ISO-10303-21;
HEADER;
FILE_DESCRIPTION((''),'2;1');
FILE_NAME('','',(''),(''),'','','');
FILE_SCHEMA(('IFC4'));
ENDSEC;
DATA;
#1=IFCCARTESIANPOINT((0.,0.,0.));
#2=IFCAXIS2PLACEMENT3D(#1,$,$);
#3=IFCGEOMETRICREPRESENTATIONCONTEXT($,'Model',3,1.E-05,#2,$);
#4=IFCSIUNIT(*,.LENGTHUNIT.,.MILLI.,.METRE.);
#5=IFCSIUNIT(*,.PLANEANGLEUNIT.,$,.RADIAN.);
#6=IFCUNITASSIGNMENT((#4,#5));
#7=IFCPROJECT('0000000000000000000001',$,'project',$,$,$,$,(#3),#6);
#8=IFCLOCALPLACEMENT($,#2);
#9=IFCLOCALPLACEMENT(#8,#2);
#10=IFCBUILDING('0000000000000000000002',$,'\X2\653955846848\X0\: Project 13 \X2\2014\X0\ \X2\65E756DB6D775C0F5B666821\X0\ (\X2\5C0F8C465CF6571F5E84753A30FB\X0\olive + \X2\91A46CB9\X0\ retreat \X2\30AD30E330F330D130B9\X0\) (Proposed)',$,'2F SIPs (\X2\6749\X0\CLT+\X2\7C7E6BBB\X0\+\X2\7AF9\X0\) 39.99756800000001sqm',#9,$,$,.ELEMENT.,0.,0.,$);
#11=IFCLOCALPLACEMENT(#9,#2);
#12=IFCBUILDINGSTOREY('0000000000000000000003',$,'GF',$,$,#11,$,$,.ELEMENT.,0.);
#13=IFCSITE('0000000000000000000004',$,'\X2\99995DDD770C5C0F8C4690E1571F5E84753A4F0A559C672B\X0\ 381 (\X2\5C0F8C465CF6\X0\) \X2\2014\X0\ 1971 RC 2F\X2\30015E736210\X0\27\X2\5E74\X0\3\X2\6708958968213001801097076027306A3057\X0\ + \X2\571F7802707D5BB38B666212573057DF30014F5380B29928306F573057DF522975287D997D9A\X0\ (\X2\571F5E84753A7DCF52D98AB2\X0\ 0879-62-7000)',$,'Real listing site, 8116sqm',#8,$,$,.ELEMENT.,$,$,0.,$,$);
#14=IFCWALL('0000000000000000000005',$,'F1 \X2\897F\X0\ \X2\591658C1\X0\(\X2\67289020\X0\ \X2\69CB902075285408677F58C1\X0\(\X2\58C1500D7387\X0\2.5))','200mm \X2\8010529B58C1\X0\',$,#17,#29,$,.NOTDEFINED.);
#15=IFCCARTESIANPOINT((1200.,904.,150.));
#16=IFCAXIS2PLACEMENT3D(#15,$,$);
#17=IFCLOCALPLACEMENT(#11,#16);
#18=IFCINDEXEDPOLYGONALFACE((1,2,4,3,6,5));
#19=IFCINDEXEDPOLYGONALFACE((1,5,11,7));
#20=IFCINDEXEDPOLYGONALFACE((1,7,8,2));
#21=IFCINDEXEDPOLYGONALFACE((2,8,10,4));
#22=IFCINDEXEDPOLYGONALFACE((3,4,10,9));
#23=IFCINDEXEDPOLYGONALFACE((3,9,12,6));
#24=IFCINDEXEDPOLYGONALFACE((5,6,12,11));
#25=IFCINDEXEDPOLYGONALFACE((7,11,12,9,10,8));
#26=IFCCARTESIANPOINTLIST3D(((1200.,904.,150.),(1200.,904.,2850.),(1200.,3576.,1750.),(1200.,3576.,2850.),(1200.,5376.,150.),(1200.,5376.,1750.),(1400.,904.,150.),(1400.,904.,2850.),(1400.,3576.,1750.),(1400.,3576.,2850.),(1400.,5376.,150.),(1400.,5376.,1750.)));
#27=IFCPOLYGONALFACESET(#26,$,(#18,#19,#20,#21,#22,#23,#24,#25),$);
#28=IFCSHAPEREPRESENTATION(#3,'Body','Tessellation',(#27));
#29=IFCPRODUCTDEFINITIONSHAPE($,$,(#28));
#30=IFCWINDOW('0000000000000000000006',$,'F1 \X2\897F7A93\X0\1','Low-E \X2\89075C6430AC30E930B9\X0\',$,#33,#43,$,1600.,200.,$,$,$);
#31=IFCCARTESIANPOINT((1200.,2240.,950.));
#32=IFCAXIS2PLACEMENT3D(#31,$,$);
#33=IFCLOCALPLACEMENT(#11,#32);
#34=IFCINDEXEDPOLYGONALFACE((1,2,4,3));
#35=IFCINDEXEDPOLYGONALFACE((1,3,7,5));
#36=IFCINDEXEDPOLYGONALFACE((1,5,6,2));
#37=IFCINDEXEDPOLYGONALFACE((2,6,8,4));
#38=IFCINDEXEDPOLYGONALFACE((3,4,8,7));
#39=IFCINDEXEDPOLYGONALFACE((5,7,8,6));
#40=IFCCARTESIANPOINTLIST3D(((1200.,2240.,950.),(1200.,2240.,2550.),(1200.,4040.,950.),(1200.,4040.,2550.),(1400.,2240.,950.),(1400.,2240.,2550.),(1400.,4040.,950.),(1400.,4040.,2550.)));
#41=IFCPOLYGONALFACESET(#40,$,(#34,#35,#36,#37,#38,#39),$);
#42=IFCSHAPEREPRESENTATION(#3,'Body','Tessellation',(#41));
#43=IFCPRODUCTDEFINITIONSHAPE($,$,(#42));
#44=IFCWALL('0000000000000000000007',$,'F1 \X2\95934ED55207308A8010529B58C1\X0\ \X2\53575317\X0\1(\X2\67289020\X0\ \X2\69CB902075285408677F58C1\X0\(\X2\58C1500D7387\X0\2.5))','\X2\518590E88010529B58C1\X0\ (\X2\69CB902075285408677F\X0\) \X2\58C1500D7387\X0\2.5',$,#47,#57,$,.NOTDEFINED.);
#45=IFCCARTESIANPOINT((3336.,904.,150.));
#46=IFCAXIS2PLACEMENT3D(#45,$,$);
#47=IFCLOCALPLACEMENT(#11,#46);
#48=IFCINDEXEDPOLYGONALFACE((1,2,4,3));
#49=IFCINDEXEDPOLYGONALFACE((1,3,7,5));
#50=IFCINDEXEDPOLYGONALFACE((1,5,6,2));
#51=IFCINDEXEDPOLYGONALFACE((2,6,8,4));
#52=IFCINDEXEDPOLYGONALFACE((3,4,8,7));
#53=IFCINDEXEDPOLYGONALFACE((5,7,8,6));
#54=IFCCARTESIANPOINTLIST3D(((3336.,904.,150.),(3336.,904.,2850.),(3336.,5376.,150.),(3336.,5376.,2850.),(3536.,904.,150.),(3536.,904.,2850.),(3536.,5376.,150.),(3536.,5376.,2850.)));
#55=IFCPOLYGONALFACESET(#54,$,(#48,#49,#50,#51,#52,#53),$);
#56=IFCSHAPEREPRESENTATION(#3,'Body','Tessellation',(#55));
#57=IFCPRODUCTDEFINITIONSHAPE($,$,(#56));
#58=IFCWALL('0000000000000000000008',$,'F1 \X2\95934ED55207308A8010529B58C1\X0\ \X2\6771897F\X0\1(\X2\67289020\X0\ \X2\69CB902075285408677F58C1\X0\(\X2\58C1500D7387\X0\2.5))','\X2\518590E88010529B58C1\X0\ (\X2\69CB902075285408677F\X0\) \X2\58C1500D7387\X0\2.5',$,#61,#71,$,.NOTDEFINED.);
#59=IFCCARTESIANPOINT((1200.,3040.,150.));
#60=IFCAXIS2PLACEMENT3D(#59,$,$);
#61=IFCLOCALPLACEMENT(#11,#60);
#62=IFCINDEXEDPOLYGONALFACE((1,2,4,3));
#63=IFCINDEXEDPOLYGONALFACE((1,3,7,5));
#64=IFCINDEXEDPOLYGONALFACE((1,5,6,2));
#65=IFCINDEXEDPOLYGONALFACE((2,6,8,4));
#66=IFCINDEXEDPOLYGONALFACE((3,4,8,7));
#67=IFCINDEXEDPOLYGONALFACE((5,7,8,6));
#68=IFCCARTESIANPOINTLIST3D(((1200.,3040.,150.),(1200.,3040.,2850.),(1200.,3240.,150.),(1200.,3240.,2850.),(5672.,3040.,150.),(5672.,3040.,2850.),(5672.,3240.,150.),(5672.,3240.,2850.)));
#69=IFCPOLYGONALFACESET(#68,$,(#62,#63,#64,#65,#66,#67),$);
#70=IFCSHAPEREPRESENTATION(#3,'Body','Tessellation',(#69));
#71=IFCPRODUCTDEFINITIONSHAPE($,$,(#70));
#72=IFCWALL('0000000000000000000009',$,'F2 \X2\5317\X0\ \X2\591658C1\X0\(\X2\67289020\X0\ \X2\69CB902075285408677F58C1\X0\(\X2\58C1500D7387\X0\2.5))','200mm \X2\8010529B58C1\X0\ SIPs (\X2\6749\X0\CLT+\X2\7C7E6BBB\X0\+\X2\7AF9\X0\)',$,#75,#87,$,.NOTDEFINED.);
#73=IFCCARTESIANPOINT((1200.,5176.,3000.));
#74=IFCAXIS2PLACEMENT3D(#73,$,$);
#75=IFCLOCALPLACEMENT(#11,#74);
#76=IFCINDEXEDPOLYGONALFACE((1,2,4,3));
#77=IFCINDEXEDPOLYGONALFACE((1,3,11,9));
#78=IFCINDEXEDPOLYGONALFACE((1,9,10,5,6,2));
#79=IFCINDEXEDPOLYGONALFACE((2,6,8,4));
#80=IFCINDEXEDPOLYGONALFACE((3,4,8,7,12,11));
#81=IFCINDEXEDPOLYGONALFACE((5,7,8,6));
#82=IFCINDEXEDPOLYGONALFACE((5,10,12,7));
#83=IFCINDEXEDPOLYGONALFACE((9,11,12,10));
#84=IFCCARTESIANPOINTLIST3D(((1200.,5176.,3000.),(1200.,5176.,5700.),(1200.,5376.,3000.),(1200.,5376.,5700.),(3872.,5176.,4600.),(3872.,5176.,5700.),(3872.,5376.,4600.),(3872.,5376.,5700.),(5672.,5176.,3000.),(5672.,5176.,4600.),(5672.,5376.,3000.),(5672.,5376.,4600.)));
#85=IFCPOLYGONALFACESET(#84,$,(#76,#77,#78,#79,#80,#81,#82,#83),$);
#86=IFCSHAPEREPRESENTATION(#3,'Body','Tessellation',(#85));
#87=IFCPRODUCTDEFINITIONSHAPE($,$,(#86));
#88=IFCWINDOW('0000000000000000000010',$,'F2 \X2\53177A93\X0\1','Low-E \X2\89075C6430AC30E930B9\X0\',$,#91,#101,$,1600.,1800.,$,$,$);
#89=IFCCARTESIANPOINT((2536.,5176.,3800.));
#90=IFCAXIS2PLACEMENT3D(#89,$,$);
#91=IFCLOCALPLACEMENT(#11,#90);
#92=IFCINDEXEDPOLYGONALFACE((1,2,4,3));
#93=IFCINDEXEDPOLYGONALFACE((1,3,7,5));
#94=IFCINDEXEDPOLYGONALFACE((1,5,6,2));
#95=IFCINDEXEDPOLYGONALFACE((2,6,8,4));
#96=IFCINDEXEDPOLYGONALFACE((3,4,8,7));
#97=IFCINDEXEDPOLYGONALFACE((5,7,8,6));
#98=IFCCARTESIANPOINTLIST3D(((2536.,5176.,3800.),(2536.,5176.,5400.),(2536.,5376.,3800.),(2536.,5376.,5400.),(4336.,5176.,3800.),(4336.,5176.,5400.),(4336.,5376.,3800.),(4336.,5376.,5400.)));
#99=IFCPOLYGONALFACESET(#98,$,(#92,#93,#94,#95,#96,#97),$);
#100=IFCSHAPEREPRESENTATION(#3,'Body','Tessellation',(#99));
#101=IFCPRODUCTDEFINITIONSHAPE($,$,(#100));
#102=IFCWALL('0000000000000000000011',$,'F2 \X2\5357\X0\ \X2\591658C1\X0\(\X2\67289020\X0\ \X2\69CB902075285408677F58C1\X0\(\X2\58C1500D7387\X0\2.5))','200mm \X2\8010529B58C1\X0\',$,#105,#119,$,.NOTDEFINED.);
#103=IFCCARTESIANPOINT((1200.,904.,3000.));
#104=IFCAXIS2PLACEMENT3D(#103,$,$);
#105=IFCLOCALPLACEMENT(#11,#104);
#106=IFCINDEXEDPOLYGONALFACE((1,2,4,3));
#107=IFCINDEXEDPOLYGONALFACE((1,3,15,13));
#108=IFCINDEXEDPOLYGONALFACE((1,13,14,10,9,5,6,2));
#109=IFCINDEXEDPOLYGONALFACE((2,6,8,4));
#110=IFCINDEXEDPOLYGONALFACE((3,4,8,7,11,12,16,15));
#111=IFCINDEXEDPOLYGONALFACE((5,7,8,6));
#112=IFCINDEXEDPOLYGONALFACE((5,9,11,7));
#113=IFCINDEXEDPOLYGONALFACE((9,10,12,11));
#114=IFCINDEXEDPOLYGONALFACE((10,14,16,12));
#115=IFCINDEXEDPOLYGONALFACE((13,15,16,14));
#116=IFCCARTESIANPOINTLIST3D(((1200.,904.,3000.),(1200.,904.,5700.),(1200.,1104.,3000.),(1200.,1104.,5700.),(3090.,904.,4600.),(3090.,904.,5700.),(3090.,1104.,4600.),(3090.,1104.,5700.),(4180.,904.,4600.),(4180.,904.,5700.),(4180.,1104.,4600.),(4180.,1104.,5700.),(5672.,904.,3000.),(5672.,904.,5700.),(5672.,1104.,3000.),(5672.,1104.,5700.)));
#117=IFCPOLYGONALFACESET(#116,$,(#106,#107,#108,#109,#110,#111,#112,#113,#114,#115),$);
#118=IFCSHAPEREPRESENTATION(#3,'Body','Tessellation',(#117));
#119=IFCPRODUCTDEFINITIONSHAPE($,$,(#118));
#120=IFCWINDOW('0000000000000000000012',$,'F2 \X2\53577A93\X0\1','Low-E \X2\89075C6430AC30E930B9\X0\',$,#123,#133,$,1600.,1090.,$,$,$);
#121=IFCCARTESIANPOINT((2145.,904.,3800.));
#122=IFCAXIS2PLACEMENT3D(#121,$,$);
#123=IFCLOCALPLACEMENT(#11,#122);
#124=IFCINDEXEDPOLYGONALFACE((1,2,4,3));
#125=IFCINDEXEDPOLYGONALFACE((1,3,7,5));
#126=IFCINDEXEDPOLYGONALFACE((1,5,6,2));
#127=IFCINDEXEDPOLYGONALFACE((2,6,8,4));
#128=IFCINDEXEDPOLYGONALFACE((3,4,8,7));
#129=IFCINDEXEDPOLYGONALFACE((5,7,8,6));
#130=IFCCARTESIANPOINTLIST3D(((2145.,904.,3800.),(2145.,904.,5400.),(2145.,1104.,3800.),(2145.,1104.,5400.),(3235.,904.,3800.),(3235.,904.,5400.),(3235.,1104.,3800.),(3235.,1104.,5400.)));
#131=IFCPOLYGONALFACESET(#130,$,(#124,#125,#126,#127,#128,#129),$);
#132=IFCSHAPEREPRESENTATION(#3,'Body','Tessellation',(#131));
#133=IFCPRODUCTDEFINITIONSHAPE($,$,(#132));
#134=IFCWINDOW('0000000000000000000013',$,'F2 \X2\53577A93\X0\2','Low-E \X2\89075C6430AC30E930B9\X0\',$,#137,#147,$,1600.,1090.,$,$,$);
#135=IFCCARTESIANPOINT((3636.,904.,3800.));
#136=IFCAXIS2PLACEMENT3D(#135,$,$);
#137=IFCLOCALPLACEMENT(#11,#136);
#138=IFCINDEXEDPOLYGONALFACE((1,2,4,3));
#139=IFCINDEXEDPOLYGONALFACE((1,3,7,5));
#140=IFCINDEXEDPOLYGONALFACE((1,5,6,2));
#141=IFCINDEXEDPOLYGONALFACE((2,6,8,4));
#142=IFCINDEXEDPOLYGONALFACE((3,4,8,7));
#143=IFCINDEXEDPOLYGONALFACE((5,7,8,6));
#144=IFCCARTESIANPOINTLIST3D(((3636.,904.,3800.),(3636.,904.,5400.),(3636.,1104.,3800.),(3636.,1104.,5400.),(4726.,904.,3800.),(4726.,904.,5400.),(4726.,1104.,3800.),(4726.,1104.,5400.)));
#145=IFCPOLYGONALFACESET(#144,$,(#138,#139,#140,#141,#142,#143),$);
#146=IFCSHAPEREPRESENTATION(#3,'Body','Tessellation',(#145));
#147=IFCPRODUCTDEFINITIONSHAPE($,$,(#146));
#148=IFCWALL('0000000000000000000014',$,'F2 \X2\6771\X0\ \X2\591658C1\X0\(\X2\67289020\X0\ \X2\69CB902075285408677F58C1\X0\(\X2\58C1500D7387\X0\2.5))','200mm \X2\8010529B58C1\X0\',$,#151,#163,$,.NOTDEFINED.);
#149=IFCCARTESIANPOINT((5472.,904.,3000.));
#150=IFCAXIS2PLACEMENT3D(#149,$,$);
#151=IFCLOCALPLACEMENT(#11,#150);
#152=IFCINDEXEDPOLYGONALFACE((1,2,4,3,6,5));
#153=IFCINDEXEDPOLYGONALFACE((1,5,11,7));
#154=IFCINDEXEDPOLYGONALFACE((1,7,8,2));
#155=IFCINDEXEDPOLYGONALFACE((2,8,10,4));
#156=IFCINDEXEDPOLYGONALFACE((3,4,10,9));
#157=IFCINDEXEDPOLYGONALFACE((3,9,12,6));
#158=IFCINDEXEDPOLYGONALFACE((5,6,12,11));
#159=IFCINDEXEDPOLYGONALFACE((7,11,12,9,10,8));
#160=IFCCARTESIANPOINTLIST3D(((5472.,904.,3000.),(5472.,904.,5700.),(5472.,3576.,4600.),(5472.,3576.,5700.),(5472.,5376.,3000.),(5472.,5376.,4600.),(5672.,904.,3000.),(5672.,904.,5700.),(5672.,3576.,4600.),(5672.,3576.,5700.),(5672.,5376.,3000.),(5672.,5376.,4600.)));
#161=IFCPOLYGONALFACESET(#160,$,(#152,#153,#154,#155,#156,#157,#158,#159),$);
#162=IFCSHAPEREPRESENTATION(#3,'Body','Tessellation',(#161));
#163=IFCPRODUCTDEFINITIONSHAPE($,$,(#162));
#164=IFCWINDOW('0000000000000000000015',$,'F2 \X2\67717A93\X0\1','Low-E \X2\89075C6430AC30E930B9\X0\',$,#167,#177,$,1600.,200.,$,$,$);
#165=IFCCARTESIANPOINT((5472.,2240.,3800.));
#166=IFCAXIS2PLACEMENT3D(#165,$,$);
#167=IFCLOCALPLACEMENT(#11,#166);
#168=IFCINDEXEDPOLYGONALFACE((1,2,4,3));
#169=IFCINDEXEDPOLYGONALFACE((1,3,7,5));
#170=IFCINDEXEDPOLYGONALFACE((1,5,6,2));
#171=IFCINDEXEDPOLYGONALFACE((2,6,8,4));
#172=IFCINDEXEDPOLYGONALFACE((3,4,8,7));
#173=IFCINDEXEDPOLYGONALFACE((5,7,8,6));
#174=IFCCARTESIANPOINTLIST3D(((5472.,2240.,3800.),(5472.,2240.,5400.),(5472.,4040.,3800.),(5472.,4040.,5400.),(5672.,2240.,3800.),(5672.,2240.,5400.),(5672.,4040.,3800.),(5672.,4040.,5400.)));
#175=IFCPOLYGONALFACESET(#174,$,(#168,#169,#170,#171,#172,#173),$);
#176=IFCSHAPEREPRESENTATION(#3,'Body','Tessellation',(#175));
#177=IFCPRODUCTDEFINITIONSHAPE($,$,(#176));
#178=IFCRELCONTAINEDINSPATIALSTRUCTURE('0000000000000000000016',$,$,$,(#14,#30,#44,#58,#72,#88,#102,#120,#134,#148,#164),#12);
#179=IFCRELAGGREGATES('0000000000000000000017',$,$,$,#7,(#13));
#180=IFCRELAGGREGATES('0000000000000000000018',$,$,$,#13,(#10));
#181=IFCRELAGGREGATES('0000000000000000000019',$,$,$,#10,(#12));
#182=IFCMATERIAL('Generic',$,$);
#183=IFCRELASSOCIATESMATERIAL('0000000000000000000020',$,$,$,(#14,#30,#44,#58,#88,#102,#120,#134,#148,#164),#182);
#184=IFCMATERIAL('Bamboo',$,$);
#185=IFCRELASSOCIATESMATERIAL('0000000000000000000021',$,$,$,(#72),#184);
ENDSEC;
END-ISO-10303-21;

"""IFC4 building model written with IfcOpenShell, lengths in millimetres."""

from ifc_helpers import new_model, si_unit, frame, frame_2d, origin, place, context, project, spatial, rectangle, extrude, material, element, fill, save


model = new_model("IFC4")

# Units and contexts
model_context = context("Model", 3, precision=1e-05, world=origin())
ifc_project = project(units=[si_unit("LENGTHUNIT", "METRE", prefix="MILLI"), si_unit("PLANEANGLEUNIT", "RADIAN")], contexts=[model_context])

# Site, building, storey
site_placement = place(None, origin())
site = spatial("IfcSite", under=ifc_project, at=site_placement, Name="香川県小豆郡土庄町伊喜末 381 (小豆島) — 1971 RC 2F、平成27年3月閉校、耐震性なし + 土砂災害警戒地域、体育館は地域利用継続 (土庄町総務課 0879-62-7000)", ObjectType="Real listing site, 8116sqm", CompositionType="ELEMENT", RefElevation=0.0)
building_placement = place(site_placement, origin())
building = spatial("IfcBuilding", under=site, at=building_placement, Name="改善案: Project 13 — 旧四海小学校 (小豆島土庄町・olive + 醤油 retreat キャンパス) (Proposed)", ObjectType="2F SIPs (杉CLT+籾殻+竹) 39.99756800000001sqm", CompositionType="ELEMENT", ElevationOfRefHeight=0.0, ElevationOfTerrain=0.0)
storey_placement = place(building_placement, origin())
storey = spatial("IfcBuildingStorey", under=building, at=storey_placement, Name="GF", CompositionType="ELEMENT", Elevation=0.0)

# Shared definitions
ifc_material_1 = material(Name="Generic")

# Shared definitions
ifc_material_2 = material(Name="Bamboo")

# Wall, opening, window
wall_1_placement = place(storey_placement, frame((1200.0, 904.0, 150.0)))
wall_1 = element("IfcWall", 1, at=wall_1_placement, inside=storey, material=ifc_material_1, Name="F1 西 外壁(木造 構造用合板壁(壁倍率2.5))", Description="200mm 耐力壁", PredefinedType="NOTDEFINED", context=model_context, shape_type="SweptSolid", body=[
    extrude(rectangle(XDim=200.0, YDim=4472.0, at=frame_2d((100.0, 2236.0))), frame((1200.0, 904.0, 150.0)), (0.0, 0.0, 1.0), 2700.0),
])
opening_1_placement = place(storey_placement, frame((1200.0, 2240.0, 950.0)))
opening_1 = element("IfcOpeningElement", 2, at=opening_1_placement, cuts=wall_1, PredefinedType="NOTDEFINED", context=model_context, shape_type="SweptSolid", body=[
    extrude(rectangle(XDim=200.0, YDim=1800.0, at=frame_2d((100.0, 900.0))), frame((1200.0, 2240.0, 950.0)), (0.0, 0.0, 1.0), 1600.0),
])
window_1_placement = place(storey_placement, frame((1200.0, 2240.0, 950.0)))
window_1 = element("IfcWindow", 3, at=window_1_placement, inside=storey, material=ifc_material_1, Name="F1 西窓1", Description="Low-E 複層ガラス", OverallHeight=1600.0, OverallWidth=200.0, context=model_context, shape_type="SweptSolid", body=[
    extrude(rectangle(XDim=200.0, YDim=1800.0, at=frame_2d((100.0, 900.0))), frame((1200.0, 2240.0, 950.0)), (0.0, 0.0, 1.0), 1600.0),
])
fill(opening_1, window_1)

# Walls
wall_2_placement = place(storey_placement, frame((3336.0, 904.0, 150.0)))
element("IfcWall", 4, at=wall_2_placement, inside=storey, material=ifc_material_1, Name="F1 間仕切り耐力壁 南北1(木造 構造用合板壁(壁倍率2.5))", Description="内部耐力壁 (構造用合板) 壁倍率2.5", PredefinedType="NOTDEFINED", context=model_context, shape_type="SweptSolid", body=[
    extrude(rectangle(XDim=200.0, YDim=4472.0, at=frame_2d((100.0, 2236.0))), frame((3336.0, 904.0, 150.0)), (0.0, 0.0, 1.0), 2700.0),
])
wall_3_placement = place(storey_placement, frame((1200.0, 3040.0, 150.0)))
element("IfcWall", 5, at=wall_3_placement, inside=storey, material=ifc_material_1, Name="F1 間仕切り耐力壁 東西1(木造 構造用合板壁(壁倍率2.5))", Description="内部耐力壁 (構造用合板) 壁倍率2.5", PredefinedType="NOTDEFINED", context=model_context, shape_type="SweptSolid", body=[
    extrude(rectangle(XDim=4472.0, YDim=200.0, at=frame_2d((2236.0, 100.0))), frame((1200.0, 3040.0, 150.0)), (0.0, 0.0, 1.0), 2700.0),
])

# Wall, opening, window
wall_4_placement = place(storey_placement, frame((1200.0, 5176.0, 3000.0)))
wall_4 = element("IfcWall", 6, at=wall_4_placement, inside=storey, material=ifc_material_2, Name="F2 北 外壁(木造 構造用合板壁(壁倍率2.5))", Description="200mm 耐力壁 SIPs (杉CLT+籾殻+竹)", PredefinedType="NOTDEFINED", context=model_context, shape_type="SweptSolid", body=[
    extrude(rectangle(XDim=4472.0, YDim=200.0, at=frame_2d((2236.0, 100.0))), frame((1200.0, 5176.0, 3000.0)), (0.0, 0.0, 1.0), 2700.0),
])
opening_2_placement = place(storey_placement, frame((2536.0, 5176.0, 3800.0)))
opening_2 = element("IfcOpeningElement", 7, at=opening_2_placement, cuts=wall_4, PredefinedType="NOTDEFINED", context=model_context, shape_type="SweptSolid", body=[
    extrude(rectangle(XDim=1800.0, YDim=200.0, at=frame_2d((900.0, 100.0))), frame((2536.0, 5176.0, 3800.0)), (0.0, 0.0, 1.0), 1600.0),
])
window_2_placement = place(storey_placement, frame((2536.0, 5176.0, 3800.0)))
window_2 = element("IfcWindow", 8, at=window_2_placement, inside=storey, material=ifc_material_1, Name="F2 北窓1", Description="Low-E 複層ガラス", OverallHeight=1600.0, OverallWidth=1800.0, context=model_context, shape_type="SweptSolid", body=[
    extrude(rectangle(XDim=1800.0, YDim=200.0, at=frame_2d((900.0, 100.0))), frame((2536.0, 5176.0, 3800.0)), (0.0, 0.0, 1.0), 1600.0),
])
fill(opening_2, window_2)

# Wall, openings, windows
wall_5_placement = place(storey_placement, frame((1200.0, 904.0, 3000.0)))
wall_5 = element("IfcWall", 9, at=wall_5_placement, inside=storey, material=ifc_material_1, Name="F2 南 外壁(木造 構造用合板壁(壁倍率2.5))", Description="200mm 耐力壁", PredefinedType="NOTDEFINED", context=model_context, shape_type="SweptSolid", body=[
    extrude(rectangle(XDim=4472.0, YDim=200.0, at=frame_2d((2236.0, 100.0))), frame((1200.0, 904.0, 3000.0)), (0.0, 0.0, 1.0), 2700.0),
])
opening_3_placement = place(storey_placement, frame((2145.0, 904.0, 3800.0)))
opening_3 = element("IfcOpeningElement", 10, at=opening_3_placement, cuts=wall_5, PredefinedType="NOTDEFINED", context=model_context, shape_type="SweptSolid", body=[
    extrude(rectangle(XDim=1090.0, YDim=200.0, at=frame_2d((545.0, 100.0))), frame((2145.0, 904.0, 3800.0)), (0.0, 0.0, 1.0), 1600.0),
])
opening_4_placement = place(storey_placement, frame((3636.0, 904.0, 3800.0)))
opening_4 = element("IfcOpeningElement", 11, at=opening_4_placement, cuts=wall_5, PredefinedType="NOTDEFINED", context=model_context, shape_type="SweptSolid", body=[
    extrude(rectangle(XDim=1090.0, YDim=200.0, at=frame_2d((545.0, 100.0))), frame((3636.0, 904.0, 3800.0)), (0.0, 0.0, 1.0), 1600.0),
])
window_3_placement = place(storey_placement, frame((2145.0, 904.0, 3800.0)))
window_3 = element("IfcWindow", 12, at=window_3_placement, inside=storey, material=ifc_material_1, Name="F2 南窓1", Description="Low-E 複層ガラス", OverallHeight=1600.0, OverallWidth=1090.0, context=model_context, shape_type="SweptSolid", body=[
    extrude(rectangle(XDim=1090.0, YDim=200.0, at=frame_2d((545.0, 100.0))), frame((2145.0, 904.0, 3800.0)), (0.0, 0.0, 1.0), 1600.0),
])
fill(opening_3, window_3)
window_4_placement = place(storey_placement, frame((3636.0, 904.0, 3800.0)))
window_4 = element("IfcWindow", 13, at=window_4_placement, inside=storey, material=ifc_material_1, Name="F2 南窓2", Description="Low-E 複層ガラス", OverallHeight=1600.0, OverallWidth=1090.0, context=model_context, shape_type="SweptSolid", body=[
    extrude(rectangle(XDim=1090.0, YDim=200.0, at=frame_2d((545.0, 100.0))), frame((3636.0, 904.0, 3800.0)), (0.0, 0.0, 1.0), 1600.0),
])
fill(opening_4, window_4)

# Wall, opening, window
wall_6_placement = place(storey_placement, frame((5472.0, 904.0, 3000.0)))
wall_6 = element("IfcWall", 14, at=wall_6_placement, inside=storey, material=ifc_material_1, Name="F2 東 外壁(木造 構造用合板壁(壁倍率2.5))", Description="200mm 耐力壁", PredefinedType="NOTDEFINED", context=model_context, shape_type="SweptSolid", body=[
    extrude(rectangle(XDim=200.0, YDim=4472.0, at=frame_2d((100.0, 2236.0))), frame((5472.0, 904.0, 3000.0)), (0.0, 0.0, 1.0), 2700.0),
])
opening_5_placement = place(storey_placement, frame((5472.0, 2240.0, 3800.0)))
opening_5 = element("IfcOpeningElement", 15, at=opening_5_placement, cuts=wall_6, PredefinedType="NOTDEFINED", context=model_context, shape_type="SweptSolid", body=[
    extrude(rectangle(XDim=200.0, YDim=1800.0, at=frame_2d((100.0, 900.0))), frame((5472.0, 2240.0, 3800.0)), (0.0, 0.0, 1.0), 1600.0),
])
window_5_placement = place(storey_placement, frame((5472.0, 2240.0, 3800.0)))
window_5 = element("IfcWindow", 16, at=window_5_placement, inside=storey, material=ifc_material_1, Name="F2 東窓1", Description="Low-E 複層ガラス", OverallHeight=1600.0, OverallWidth=200.0, context=model_context, shape_type="SweptSolid", body=[
    extrude(rectangle(XDim=200.0, YDim=1800.0, at=frame_2d((100.0, 900.0))), frame((5472.0, 2240.0, 3800.0)), (0.0, 0.0, 1.0), 1600.0),
])
fill(opening_5, window_5)

save(model, "model.ifc")
